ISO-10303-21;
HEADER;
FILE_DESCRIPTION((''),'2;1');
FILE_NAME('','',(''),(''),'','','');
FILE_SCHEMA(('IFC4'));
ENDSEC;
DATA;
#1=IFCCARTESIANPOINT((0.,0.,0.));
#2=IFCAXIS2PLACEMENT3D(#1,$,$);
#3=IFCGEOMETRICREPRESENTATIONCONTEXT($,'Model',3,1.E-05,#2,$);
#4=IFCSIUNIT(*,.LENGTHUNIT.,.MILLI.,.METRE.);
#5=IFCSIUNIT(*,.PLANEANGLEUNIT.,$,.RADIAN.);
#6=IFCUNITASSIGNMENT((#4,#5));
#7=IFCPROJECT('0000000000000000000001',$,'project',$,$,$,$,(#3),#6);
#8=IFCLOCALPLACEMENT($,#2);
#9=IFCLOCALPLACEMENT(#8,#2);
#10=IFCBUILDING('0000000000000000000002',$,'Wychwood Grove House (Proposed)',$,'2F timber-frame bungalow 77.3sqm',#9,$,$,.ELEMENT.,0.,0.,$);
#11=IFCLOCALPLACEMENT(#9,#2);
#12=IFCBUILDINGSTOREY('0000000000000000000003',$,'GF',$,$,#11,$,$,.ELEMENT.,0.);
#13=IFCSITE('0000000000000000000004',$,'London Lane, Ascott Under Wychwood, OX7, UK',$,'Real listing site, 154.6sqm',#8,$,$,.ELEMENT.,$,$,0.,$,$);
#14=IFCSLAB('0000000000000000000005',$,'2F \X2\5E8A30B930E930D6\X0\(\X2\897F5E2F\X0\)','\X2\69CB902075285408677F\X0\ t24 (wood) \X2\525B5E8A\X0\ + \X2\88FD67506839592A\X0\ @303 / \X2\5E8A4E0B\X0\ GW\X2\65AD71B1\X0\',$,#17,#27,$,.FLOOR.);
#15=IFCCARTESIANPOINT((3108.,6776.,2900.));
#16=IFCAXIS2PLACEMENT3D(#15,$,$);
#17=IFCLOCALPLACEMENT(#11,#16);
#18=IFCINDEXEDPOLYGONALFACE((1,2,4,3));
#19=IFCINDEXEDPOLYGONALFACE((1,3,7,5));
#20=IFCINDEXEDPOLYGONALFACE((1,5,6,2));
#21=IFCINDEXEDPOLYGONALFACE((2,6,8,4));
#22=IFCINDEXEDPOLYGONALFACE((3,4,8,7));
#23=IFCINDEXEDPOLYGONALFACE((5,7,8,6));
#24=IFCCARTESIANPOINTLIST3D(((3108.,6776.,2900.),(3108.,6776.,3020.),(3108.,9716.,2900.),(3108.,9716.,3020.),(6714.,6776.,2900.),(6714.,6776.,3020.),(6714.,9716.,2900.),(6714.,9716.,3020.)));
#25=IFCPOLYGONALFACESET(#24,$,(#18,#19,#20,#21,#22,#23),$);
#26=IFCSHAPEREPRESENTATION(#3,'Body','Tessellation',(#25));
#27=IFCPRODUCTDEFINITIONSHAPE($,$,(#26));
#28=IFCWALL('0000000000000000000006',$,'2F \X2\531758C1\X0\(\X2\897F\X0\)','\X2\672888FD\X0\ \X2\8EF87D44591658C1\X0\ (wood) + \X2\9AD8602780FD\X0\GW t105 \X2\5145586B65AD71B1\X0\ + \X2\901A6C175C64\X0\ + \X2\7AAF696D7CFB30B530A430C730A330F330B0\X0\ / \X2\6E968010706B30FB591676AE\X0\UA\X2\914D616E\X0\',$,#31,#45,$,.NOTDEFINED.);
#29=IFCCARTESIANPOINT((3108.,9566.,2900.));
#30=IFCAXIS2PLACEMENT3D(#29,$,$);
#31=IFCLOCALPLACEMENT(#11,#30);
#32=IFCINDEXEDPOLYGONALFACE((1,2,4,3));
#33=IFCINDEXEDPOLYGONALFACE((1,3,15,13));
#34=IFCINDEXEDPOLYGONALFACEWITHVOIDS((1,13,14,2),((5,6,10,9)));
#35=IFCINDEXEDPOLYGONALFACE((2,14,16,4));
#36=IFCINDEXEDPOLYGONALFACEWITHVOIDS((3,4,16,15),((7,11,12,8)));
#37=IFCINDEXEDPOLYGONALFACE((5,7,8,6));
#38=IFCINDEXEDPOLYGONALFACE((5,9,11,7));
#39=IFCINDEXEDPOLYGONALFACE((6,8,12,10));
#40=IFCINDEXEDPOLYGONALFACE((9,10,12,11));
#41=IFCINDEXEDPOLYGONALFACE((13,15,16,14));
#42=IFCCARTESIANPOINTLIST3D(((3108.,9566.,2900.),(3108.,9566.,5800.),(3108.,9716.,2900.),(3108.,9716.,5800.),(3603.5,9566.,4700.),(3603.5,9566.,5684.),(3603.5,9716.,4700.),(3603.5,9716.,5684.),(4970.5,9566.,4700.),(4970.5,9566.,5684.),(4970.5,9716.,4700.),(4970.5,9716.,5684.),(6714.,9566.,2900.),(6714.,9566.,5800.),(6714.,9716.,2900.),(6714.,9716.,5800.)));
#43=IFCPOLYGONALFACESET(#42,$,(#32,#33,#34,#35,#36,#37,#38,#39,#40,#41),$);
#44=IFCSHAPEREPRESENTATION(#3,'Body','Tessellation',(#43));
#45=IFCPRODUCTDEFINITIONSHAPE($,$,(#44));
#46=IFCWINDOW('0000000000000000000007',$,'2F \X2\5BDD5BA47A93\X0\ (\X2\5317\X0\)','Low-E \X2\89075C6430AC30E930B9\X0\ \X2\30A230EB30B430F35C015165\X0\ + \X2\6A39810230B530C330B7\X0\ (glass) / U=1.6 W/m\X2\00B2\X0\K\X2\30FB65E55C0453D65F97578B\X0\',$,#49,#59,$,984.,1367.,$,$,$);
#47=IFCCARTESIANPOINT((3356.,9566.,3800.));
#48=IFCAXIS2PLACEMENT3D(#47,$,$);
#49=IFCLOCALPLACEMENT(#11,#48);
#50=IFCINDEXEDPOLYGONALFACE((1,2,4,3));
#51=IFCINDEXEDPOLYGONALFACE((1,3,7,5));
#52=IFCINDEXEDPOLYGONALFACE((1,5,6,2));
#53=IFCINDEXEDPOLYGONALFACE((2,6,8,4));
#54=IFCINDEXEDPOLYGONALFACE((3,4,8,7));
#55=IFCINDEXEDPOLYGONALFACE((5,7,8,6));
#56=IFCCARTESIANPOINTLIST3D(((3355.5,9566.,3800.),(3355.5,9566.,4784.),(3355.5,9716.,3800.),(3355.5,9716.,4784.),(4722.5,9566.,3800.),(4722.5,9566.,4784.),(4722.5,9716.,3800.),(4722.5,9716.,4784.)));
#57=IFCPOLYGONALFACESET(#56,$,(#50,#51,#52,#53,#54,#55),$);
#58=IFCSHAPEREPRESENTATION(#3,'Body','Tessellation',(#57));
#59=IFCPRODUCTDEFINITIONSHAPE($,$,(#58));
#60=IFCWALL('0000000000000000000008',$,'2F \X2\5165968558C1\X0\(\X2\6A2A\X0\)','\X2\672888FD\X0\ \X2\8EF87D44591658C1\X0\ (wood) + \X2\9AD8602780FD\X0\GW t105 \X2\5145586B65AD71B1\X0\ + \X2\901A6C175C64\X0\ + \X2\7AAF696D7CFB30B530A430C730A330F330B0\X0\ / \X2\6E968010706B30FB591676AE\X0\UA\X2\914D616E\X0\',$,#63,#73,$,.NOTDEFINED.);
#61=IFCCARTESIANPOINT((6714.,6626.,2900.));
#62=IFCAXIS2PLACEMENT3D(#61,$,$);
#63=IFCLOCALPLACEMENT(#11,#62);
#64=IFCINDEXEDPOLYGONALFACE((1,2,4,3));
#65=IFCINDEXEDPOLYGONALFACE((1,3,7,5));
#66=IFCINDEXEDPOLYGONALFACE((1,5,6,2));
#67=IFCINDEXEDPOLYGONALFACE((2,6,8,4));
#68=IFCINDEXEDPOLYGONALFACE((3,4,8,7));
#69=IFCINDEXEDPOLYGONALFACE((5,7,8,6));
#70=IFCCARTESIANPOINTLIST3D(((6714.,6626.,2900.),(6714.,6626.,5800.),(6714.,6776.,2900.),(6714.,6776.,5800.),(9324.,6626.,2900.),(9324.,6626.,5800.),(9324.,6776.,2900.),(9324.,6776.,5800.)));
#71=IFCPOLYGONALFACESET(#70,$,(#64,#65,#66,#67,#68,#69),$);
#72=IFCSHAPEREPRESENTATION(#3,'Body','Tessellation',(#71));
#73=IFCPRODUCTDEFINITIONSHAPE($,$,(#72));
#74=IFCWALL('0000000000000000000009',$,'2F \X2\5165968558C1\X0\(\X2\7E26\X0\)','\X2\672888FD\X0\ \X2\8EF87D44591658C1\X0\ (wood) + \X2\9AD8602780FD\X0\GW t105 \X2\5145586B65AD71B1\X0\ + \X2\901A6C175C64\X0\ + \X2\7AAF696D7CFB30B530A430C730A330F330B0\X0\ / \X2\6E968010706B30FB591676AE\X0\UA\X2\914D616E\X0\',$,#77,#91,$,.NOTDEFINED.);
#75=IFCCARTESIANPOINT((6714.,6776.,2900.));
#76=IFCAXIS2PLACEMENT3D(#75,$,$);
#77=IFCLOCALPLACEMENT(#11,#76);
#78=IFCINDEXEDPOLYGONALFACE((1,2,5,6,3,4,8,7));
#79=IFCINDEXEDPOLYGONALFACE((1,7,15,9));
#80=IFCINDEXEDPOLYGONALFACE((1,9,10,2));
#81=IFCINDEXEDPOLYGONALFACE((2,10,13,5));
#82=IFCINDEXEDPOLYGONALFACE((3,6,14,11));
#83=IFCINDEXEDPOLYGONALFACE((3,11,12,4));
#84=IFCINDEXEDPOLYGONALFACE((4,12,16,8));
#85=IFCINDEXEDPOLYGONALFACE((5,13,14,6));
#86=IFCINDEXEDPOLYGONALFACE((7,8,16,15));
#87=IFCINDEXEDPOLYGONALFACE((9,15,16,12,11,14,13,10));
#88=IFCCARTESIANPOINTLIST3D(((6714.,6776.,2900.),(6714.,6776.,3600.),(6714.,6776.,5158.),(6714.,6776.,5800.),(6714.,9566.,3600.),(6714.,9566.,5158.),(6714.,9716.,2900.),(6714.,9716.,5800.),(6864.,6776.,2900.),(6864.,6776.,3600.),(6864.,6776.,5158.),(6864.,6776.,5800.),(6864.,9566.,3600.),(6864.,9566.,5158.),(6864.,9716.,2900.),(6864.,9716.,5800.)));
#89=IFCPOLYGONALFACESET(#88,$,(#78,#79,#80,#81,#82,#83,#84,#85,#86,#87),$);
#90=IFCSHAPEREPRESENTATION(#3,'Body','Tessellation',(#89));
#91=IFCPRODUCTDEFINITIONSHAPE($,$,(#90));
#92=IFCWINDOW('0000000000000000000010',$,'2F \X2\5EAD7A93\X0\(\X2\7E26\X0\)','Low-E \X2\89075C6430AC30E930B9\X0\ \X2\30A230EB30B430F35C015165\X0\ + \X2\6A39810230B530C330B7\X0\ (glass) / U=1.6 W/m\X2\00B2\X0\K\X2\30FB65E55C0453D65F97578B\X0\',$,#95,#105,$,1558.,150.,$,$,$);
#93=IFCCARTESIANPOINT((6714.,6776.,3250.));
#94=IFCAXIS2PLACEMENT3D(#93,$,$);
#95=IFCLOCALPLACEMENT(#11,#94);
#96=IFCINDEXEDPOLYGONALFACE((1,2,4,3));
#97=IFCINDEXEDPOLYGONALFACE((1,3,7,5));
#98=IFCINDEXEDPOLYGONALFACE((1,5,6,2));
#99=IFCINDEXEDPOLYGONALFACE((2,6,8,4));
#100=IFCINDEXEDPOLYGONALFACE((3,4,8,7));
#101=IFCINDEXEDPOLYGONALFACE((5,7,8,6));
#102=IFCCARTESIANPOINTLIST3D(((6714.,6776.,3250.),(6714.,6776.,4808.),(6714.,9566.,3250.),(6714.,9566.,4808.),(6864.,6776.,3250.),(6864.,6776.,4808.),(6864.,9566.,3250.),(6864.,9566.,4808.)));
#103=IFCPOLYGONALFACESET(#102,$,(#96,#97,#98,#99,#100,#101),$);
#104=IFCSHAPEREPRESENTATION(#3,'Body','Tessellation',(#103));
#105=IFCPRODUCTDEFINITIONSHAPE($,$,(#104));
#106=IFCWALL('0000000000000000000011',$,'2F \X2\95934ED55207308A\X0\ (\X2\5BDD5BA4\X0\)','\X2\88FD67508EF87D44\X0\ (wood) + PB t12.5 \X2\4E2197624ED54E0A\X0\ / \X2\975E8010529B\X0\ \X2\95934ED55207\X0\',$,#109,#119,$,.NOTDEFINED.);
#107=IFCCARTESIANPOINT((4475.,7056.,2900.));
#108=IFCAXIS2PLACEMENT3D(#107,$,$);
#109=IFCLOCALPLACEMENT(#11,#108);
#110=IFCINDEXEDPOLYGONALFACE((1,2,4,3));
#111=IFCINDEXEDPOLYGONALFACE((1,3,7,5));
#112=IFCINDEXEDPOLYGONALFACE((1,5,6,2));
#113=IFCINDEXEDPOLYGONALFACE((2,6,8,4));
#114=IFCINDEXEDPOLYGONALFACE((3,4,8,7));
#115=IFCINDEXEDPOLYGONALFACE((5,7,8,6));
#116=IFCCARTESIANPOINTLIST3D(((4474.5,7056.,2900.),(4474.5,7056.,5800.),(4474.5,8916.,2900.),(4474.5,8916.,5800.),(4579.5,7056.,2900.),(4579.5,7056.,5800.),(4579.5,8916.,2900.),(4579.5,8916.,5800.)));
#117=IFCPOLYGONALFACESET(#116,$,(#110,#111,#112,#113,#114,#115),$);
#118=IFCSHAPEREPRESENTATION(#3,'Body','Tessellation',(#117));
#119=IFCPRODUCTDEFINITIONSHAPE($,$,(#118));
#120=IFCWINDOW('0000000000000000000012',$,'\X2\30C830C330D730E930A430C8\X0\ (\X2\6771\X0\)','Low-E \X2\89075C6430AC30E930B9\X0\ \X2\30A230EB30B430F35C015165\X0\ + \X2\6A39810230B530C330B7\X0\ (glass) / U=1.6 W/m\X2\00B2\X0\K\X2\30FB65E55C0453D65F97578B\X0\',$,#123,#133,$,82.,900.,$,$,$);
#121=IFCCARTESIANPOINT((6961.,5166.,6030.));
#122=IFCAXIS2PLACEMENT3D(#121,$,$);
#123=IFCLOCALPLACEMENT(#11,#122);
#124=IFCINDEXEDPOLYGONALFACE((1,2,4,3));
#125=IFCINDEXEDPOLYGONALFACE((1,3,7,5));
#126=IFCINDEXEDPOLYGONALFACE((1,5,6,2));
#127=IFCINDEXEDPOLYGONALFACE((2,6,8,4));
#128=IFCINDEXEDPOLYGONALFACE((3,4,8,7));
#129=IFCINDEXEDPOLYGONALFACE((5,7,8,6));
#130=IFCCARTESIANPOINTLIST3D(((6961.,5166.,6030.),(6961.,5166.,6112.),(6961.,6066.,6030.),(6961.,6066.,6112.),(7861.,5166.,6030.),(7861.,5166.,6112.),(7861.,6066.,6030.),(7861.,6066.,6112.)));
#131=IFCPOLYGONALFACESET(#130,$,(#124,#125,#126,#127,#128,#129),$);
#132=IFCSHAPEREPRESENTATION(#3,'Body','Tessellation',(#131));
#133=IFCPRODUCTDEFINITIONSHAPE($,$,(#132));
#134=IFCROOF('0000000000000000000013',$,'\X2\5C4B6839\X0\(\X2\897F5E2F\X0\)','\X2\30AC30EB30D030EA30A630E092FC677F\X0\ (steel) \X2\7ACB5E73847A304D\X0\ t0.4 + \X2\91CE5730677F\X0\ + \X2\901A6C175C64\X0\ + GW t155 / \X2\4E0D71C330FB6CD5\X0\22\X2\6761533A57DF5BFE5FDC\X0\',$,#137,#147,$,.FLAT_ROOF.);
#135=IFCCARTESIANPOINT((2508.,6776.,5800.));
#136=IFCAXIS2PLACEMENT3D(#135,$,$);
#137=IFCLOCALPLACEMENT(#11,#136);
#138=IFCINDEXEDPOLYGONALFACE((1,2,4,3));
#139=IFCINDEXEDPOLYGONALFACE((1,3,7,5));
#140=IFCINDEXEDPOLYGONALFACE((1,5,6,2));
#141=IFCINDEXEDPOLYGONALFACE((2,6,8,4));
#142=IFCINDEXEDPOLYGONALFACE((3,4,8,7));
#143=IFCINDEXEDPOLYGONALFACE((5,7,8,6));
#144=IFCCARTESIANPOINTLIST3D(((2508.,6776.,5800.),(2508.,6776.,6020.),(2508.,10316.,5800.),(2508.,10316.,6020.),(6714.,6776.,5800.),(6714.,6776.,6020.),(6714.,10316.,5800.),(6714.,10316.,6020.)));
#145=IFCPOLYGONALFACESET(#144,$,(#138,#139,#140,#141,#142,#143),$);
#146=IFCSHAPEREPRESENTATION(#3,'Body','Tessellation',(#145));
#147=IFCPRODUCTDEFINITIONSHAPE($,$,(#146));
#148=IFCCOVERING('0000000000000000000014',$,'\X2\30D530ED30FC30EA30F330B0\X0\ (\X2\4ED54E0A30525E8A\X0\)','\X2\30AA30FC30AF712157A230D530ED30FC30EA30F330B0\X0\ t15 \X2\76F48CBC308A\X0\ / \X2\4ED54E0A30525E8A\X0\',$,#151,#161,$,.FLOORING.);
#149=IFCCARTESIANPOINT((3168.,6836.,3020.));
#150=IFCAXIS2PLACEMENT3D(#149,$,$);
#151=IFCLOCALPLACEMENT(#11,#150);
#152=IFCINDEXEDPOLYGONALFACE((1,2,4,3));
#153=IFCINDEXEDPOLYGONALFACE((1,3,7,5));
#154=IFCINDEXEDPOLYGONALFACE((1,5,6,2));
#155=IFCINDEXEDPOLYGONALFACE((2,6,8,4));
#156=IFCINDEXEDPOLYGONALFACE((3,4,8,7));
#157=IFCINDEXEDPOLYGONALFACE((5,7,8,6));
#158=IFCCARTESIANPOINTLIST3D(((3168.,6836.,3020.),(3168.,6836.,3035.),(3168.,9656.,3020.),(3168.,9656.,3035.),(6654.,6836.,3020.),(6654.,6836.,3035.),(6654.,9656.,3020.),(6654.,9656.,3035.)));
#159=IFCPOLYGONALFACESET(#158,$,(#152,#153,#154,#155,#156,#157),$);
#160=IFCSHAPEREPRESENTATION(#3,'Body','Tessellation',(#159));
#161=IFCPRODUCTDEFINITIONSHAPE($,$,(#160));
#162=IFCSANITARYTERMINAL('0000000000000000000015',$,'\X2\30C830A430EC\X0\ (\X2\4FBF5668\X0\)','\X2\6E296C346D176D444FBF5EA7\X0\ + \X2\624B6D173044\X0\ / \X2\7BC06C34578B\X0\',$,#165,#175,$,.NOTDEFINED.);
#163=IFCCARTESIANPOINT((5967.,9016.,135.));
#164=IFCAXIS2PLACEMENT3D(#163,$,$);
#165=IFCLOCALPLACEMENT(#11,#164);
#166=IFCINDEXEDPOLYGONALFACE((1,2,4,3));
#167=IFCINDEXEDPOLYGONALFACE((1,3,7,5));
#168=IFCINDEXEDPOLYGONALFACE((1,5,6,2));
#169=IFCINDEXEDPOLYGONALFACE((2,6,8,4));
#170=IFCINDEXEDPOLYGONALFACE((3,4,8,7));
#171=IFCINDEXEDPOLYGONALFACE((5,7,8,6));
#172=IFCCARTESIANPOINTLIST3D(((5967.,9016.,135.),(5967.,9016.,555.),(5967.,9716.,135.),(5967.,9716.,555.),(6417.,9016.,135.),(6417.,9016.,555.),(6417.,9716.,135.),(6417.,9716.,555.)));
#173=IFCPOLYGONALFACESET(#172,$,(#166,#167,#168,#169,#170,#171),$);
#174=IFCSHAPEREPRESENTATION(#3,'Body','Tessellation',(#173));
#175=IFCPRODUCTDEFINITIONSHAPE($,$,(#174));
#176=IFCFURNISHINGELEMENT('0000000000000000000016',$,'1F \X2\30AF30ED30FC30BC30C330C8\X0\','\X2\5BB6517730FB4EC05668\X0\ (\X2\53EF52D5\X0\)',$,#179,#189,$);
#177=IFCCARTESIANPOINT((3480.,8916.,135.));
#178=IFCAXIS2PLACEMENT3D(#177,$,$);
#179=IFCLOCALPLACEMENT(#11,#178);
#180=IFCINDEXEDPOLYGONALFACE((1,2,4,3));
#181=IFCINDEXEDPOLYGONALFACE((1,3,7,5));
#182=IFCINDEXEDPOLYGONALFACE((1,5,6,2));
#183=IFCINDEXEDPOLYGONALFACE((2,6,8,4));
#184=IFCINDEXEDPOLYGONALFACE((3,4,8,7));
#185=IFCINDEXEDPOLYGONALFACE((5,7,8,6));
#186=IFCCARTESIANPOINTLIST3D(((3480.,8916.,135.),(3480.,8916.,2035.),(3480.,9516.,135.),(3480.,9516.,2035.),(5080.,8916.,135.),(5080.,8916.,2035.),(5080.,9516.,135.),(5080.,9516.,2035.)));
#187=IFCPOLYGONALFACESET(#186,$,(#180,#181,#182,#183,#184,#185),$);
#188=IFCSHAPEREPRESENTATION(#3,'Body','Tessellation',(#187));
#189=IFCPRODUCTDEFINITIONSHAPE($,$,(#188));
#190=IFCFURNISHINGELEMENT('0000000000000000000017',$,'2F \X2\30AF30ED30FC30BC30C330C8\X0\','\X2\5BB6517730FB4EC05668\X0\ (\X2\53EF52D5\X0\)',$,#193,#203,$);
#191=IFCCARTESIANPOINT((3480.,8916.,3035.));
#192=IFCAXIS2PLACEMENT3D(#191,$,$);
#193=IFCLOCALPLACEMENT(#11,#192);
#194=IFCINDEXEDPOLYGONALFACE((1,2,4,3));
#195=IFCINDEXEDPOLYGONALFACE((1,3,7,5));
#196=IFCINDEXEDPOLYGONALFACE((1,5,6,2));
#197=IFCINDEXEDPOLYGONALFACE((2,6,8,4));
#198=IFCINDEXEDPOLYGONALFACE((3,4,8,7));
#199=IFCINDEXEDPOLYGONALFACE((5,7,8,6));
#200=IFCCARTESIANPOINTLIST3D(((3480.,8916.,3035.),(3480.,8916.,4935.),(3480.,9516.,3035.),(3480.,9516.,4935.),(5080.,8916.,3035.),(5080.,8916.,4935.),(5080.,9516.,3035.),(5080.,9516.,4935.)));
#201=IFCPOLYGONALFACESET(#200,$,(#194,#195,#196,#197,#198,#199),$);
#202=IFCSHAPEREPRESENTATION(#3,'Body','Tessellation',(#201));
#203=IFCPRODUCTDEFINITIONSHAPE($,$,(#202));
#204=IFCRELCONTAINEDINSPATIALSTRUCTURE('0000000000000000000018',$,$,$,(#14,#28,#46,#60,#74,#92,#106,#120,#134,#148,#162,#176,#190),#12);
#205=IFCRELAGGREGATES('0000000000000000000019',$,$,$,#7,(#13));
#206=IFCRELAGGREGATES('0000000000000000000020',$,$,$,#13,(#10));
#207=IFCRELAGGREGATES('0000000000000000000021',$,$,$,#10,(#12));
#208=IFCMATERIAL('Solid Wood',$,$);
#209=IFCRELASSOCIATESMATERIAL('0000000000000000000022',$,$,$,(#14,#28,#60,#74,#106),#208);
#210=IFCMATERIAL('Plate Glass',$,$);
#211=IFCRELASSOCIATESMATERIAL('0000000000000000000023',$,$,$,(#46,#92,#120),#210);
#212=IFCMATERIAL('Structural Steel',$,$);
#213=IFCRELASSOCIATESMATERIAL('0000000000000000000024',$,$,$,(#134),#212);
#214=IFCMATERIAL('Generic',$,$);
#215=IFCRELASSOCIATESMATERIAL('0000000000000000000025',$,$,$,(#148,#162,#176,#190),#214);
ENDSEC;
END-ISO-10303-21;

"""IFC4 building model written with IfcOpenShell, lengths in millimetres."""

from ifc_helpers import new_model, si_unit, frame, frame_2d, origin, place, context, project, spatial, rectangle, extrude, material, element, fill, save


model = new_model("IFC4")

# Units and contexts
model_context = context("Model", 3, precision=1e-05, world=origin())
ifc_project = project(units=[si_unit("LENGTHUNIT", "METRE", prefix="MILLI"), si_unit("PLANEANGLEUNIT", "RADIAN")], contexts=[model_context])

# Site, building, storey
site_placement = place(None, origin())
site = spatial("IfcSite", under=ifc_project, at=site_placement, Name="London Lane, Ascott Under Wychwood, OX7, UK", ObjectType="Real listing site, 154.6sqm", CompositionType="ELEMENT", RefElevation=0.0)
building_placement = place(site_placement, origin())
building = spatial("IfcBuilding", under=site, at=building_placement, Name="Wychwood Grove House (Proposed)", ObjectType="2F timber-frame bungalow 77.3sqm", CompositionType="ELEMENT", ElevationOfRefHeight=0.0, ElevationOfTerrain=0.0)
storey_placement = place(building_placement, origin())
storey = spatial("IfcBuildingStorey", under=building, at=storey_placement, Name="GF", CompositionType="ELEMENT", Elevation=0.0)

# Slab
ifc_material_1 = material(Name="Solid Wood")
slab_placement = place(storey_placement, frame((3108.0, 6776.0, 2900.0)))
element("IfcSlab", 1, at=slab_placement, inside=storey, material=ifc_material_1, Name="2F 床スラブ(西帯)", Description="構造用合板 t24 (wood) 剛床 + 製材根太 @303 / 床下 GW断熱", PredefinedType="FLOOR", context=model_context, shape_type="SweptSolid", body=[
    extrude(rectangle(XDim=3606.0, YDim=2940.0, at=frame_2d((1803.0, 1470.0))), frame((3108.0, 6776.0, 2900.0)), (0.0, 0.0, 1.0), 120.0),
])

# Wall, opening, window
wall_1_placement = place(storey_placement, frame((3108.0, 9566.0, 2900.0)))
wall_1 = element("IfcWall", 2, at=wall_1_placement, inside=storey, material=ifc_material_1, Name="2F 北壁(西)", Description="木製 軸組外壁 (wood) + 高性能GW t105 充填断熱 + 通気層 + 窯業系サイディング / 準耐火・外皮UA配慮", PredefinedType="NOTDEFINED", context=model_context, shape_type="SweptSolid", body=[
    extrude(rectangle(XDim=3606.0, YDim=150.0, at=frame_2d((1803.0, 75.0))), frame((3108.0, 9566.0, 2900.0)), (0.0, 0.0, 1.0), 2900.0),
])
opening_1_placement = place(storey_placement, frame((3356.0, 9566.0, 3800.0)))
opening_1 = element("IfcOpeningElement", 3, at=opening_1_placement, cuts=wall_1, PredefinedType="NOTDEFINED", context=model_context, shape_type="SweptSolid", body=[
    extrude(rectangle(XDim=1367.0, YDim=150.0, at=frame_2d((683.0, 75.0))), frame((3356.0, 9566.0, 3800.0)), (0.0, 0.0, 1.0), 984.0),
])
ifc_material_2 = material(Name="Plate Glass")
window_1_placement = place(storey_placement, frame((3356.0, 9566.0, 3800.0)))
window_1 = element("IfcWindow", 4, at=window_1_placement, inside=storey, material=ifc_material_2, Name="2F 寝室窓 (北)", Description="Low-E 複層ガラス アルゴン封入 + 樹脂サッシ (glass) / U=1.6 W/m²K・日射取得型", OverallHeight=984.0, OverallWidth=1367.0, context=model_context, shape_type="SweptSolid", body=[
    extrude(rectangle(XDim=1367.0, YDim=150.0, at=frame_2d((683.0, 75.0))), frame((3356.0, 9566.0, 3800.0)), (0.0, 0.0, 1.0), 984.0),
])
fill(opening_1, window_1)

# Wall
wall_2_placement = place(storey_placement, frame((6714.0, 6626.0, 2900.0)))
element("IfcWall", 5, at=wall_2_placement, inside=storey, material=ifc_material_1, Name="2F 入隅壁(横)", Description="木製 軸組外壁 (wood) + 高性能GW t105 充填断熱 + 通気層 + 窯業系サイディング / 準耐火・外皮UA配慮", PredefinedType="NOTDEFINED", context=model_context, shape_type="SweptSolid", body=[
    extrude(rectangle(XDim=2610.0, YDim=150.0, at=frame_2d((1305.0, 75.0))), frame((6714.0, 6626.0, 2900.0)), (0.0, 0.0, 1.0), 2900.0),
])

# Wall, opening, window
wall_3_placement = place(storey_placement, frame((6714.0, 6776.0, 2900.0)))
wall_3 = element("IfcWall", 6, at=wall_3_placement, inside=storey, material=ifc_material_1, Name="2F 入隅壁(縦)", Description="木製 軸組外壁 (wood) + 高性能GW t105 充填断熱 + 通気層 + 窯業系サイディング / 準耐火・外皮UA配慮", PredefinedType="NOTDEFINED", context=model_context, shape_type="SweptSolid", body=[
    extrude(rectangle(XDim=150.0, YDim=2940.0, at=frame_2d((75.0, 1470.0))), frame((6714.0, 6776.0, 2900.0)), (0.0, 0.0, 1.0), 2900.0),
])
opening_2_placement = place(storey_placement, frame((6714.0, 6776.0, 3250.0)))
opening_2 = element("IfcOpeningElement", 7, at=opening_2_placement, cuts=wall_3, PredefinedType="NOTDEFINED", context=model_context, shape_type="SweptSolid", body=[
    extrude(rectangle(XDim=150.0, YDim=2790.0, at=frame_2d((75.0, 1395.0))), frame((6714.0, 6776.0, 3250.0)), (0.0, 0.0, 1.0), 1558.0),
])
window_2_placement = place(storey_placement, frame((6714.0, 6776.0, 3250.0)))
window_2 = element("IfcWindow", 8, at=window_2_placement, inside=storey, material=ifc_material_2, Name="2F 庭窓(縦)", Description="Low-E 複層ガラス アルゴン封入 + 樹脂サッシ (glass) / U=1.6 W/m²K・日射取得型", OverallHeight=1558.0, OverallWidth=150.0, context=model_context, shape_type="SweptSolid", body=[
    extrude(rectangle(XDim=150.0, YDim=2790.0, at=frame_2d((75.0, 1395.0))), frame((6714.0, 6776.0, 3250.0)), (0.0, 0.0, 1.0), 1558.0),
])
fill(opening_2, window_2)

# Wall
wall_4_placement = place(storey_placement, frame((4475.0, 7056.0, 2900.0)))
element("IfcWall", 9, at=wall_4_placement, inside=storey, material=ifc_material_1, Name="2F 間仕切り (寝室)", Description="製材軸組 (wood) + PB t12.5 両面仕上 / 非耐力 間仕切", PredefinedType="NOTDEFINED", context=model_context, shape_type="SweptSolid", body=[
    extrude(rectangle(XDim=105.0, YDim=1860.0, at=frame_2d((52.0, 930.0))), frame((4475.0, 7056.0, 2900.0)), (0.0, 0.0, 1.0), 2900.0),
])

# Window
window_3_placement = place(storey_placement, frame((6961.0, 5166.0, 6030.0)))
element("IfcWindow", 10, at=window_3_placement, inside=storey, material=ifc_material_2, Name="トップライト (東)", Description="Low-E 複層ガラス アルゴン封入 + 樹脂サッシ (glass) / U=1.6 W/m²K・日射取得型", OverallHeight=82.0, OverallWidth=900.0, context=model_context, shape_type="SweptSolid", body=[
    extrude(rectangle(XDim=900.0, YDim=900.0, at=frame_2d((450.0, 450.0))), frame((6961.0, 5166.0, 6030.0)), (0.0, 0.0, 1.0), 82.0),
])

# Roof
ifc_material_3 = material(Name="Structural Steel")
for number, where, name in (
    (11, (2508.0, 6776.0, 5800.0), "屋根(西帯)"),
):
    element("IfcRoof", number, at=place(storey_placement, frame(where)), inside=storey, material=ifc_material_3, Name=name, Description="ガルバリウム鋼板 (steel) 立平葺き t0.4 + 野地板 + 通気層 + GW t155 / 不燃・法22条区域対応", PredefinedType="FLAT_ROOF", context=model_context, shape_type="SweptSolid", body=[
        extrude(rectangle(XDim=4206.0, YDim=3540.0, at=frame_2d((2103.0, 1770.0))), frame((2508.0, 6776.0, 5800.0)), (0.0, 0.0, 1.0), 220.0),
    ])

# Covering
ifc_material_4 = material(Name="Generic")
covering_placement = place(storey_placement, frame((3168.0, 6836.0, 3020.0)))
element("IfcCovering", 12, at=covering_placement, inside=storey, material=ifc_material_4, Name="フローリング (仕上げ床)", Description="オーク無垢フローリング t15 直貼り / 仕上げ床", PredefinedType="FLOORING", context=model_context, shape_type="SweptSolid", body=[
    extrude(rectangle(XDim=3486.0, YDim=2820.0, at=frame_2d((1743.0, 1410.0))), frame((3168.0, 6836.0, 3020.0)), (0.0, 0.0, 1.0), 15.0),
])

# Sanitary terminal
sanitary_terminal_placement = place(storey_placement, frame((5967.0, 9016.0, 135.0)))
element("IfcSanitaryTerminal", 13, at=sanitary_terminal_placement, inside=storey, material=ifc_material_4, Name="トイレ (便器)", Description="温水洗浄便座 + 手洗い / 節水型", PredefinedType="NOTDEFINED", context=model_context, shape_type="SweptSolid", body=[
    extrude(rectangle(XDim=450.0, YDim=700.0, at=frame_2d((225.0, 350.0))), frame((5967.0, 9016.0, 135.0)), (0.0, 0.0, 1.0), 420.0),
])

# Furnishing elements
furnishing_1_placement = place(storey_placement, frame((3480.0, 8916.0, 135.0)))
element("IfcFurnishingElement", 14, at=furnishing_1_placement, inside=storey, material=ifc_material_4, Name="1F クローゼット", Description="家具・什器 (可動)", context=model_context, shape_type="SweptSolid", body=[
    extrude(rectangle(XDim=1600.0, YDim=600.0, at=frame_2d((800.0, 300.0))), frame((3480.0, 8916.0, 135.0)), (0.0, 0.0, 1.0), 1900.0),
])
furnishing_2_placement = place(storey_placement, frame((3480.0, 8916.0, 3035.0)))
element("IfcFurnishingElement", 15, at=furnishing_2_placement, inside=storey, material=ifc_material_4, Name="2F クローゼット", Description="家具・什器 (可動)", context=model_context, shape_type="SweptSolid", body=[
    extrude(rectangle(XDim=1600.0, YDim=600.0, at=frame_2d((800.0, 300.0))), frame((3480.0, 8916.0, 3035.0)), (0.0, 0.0, 1.0), 1900.0),
])

save(model, "model.ifc")
